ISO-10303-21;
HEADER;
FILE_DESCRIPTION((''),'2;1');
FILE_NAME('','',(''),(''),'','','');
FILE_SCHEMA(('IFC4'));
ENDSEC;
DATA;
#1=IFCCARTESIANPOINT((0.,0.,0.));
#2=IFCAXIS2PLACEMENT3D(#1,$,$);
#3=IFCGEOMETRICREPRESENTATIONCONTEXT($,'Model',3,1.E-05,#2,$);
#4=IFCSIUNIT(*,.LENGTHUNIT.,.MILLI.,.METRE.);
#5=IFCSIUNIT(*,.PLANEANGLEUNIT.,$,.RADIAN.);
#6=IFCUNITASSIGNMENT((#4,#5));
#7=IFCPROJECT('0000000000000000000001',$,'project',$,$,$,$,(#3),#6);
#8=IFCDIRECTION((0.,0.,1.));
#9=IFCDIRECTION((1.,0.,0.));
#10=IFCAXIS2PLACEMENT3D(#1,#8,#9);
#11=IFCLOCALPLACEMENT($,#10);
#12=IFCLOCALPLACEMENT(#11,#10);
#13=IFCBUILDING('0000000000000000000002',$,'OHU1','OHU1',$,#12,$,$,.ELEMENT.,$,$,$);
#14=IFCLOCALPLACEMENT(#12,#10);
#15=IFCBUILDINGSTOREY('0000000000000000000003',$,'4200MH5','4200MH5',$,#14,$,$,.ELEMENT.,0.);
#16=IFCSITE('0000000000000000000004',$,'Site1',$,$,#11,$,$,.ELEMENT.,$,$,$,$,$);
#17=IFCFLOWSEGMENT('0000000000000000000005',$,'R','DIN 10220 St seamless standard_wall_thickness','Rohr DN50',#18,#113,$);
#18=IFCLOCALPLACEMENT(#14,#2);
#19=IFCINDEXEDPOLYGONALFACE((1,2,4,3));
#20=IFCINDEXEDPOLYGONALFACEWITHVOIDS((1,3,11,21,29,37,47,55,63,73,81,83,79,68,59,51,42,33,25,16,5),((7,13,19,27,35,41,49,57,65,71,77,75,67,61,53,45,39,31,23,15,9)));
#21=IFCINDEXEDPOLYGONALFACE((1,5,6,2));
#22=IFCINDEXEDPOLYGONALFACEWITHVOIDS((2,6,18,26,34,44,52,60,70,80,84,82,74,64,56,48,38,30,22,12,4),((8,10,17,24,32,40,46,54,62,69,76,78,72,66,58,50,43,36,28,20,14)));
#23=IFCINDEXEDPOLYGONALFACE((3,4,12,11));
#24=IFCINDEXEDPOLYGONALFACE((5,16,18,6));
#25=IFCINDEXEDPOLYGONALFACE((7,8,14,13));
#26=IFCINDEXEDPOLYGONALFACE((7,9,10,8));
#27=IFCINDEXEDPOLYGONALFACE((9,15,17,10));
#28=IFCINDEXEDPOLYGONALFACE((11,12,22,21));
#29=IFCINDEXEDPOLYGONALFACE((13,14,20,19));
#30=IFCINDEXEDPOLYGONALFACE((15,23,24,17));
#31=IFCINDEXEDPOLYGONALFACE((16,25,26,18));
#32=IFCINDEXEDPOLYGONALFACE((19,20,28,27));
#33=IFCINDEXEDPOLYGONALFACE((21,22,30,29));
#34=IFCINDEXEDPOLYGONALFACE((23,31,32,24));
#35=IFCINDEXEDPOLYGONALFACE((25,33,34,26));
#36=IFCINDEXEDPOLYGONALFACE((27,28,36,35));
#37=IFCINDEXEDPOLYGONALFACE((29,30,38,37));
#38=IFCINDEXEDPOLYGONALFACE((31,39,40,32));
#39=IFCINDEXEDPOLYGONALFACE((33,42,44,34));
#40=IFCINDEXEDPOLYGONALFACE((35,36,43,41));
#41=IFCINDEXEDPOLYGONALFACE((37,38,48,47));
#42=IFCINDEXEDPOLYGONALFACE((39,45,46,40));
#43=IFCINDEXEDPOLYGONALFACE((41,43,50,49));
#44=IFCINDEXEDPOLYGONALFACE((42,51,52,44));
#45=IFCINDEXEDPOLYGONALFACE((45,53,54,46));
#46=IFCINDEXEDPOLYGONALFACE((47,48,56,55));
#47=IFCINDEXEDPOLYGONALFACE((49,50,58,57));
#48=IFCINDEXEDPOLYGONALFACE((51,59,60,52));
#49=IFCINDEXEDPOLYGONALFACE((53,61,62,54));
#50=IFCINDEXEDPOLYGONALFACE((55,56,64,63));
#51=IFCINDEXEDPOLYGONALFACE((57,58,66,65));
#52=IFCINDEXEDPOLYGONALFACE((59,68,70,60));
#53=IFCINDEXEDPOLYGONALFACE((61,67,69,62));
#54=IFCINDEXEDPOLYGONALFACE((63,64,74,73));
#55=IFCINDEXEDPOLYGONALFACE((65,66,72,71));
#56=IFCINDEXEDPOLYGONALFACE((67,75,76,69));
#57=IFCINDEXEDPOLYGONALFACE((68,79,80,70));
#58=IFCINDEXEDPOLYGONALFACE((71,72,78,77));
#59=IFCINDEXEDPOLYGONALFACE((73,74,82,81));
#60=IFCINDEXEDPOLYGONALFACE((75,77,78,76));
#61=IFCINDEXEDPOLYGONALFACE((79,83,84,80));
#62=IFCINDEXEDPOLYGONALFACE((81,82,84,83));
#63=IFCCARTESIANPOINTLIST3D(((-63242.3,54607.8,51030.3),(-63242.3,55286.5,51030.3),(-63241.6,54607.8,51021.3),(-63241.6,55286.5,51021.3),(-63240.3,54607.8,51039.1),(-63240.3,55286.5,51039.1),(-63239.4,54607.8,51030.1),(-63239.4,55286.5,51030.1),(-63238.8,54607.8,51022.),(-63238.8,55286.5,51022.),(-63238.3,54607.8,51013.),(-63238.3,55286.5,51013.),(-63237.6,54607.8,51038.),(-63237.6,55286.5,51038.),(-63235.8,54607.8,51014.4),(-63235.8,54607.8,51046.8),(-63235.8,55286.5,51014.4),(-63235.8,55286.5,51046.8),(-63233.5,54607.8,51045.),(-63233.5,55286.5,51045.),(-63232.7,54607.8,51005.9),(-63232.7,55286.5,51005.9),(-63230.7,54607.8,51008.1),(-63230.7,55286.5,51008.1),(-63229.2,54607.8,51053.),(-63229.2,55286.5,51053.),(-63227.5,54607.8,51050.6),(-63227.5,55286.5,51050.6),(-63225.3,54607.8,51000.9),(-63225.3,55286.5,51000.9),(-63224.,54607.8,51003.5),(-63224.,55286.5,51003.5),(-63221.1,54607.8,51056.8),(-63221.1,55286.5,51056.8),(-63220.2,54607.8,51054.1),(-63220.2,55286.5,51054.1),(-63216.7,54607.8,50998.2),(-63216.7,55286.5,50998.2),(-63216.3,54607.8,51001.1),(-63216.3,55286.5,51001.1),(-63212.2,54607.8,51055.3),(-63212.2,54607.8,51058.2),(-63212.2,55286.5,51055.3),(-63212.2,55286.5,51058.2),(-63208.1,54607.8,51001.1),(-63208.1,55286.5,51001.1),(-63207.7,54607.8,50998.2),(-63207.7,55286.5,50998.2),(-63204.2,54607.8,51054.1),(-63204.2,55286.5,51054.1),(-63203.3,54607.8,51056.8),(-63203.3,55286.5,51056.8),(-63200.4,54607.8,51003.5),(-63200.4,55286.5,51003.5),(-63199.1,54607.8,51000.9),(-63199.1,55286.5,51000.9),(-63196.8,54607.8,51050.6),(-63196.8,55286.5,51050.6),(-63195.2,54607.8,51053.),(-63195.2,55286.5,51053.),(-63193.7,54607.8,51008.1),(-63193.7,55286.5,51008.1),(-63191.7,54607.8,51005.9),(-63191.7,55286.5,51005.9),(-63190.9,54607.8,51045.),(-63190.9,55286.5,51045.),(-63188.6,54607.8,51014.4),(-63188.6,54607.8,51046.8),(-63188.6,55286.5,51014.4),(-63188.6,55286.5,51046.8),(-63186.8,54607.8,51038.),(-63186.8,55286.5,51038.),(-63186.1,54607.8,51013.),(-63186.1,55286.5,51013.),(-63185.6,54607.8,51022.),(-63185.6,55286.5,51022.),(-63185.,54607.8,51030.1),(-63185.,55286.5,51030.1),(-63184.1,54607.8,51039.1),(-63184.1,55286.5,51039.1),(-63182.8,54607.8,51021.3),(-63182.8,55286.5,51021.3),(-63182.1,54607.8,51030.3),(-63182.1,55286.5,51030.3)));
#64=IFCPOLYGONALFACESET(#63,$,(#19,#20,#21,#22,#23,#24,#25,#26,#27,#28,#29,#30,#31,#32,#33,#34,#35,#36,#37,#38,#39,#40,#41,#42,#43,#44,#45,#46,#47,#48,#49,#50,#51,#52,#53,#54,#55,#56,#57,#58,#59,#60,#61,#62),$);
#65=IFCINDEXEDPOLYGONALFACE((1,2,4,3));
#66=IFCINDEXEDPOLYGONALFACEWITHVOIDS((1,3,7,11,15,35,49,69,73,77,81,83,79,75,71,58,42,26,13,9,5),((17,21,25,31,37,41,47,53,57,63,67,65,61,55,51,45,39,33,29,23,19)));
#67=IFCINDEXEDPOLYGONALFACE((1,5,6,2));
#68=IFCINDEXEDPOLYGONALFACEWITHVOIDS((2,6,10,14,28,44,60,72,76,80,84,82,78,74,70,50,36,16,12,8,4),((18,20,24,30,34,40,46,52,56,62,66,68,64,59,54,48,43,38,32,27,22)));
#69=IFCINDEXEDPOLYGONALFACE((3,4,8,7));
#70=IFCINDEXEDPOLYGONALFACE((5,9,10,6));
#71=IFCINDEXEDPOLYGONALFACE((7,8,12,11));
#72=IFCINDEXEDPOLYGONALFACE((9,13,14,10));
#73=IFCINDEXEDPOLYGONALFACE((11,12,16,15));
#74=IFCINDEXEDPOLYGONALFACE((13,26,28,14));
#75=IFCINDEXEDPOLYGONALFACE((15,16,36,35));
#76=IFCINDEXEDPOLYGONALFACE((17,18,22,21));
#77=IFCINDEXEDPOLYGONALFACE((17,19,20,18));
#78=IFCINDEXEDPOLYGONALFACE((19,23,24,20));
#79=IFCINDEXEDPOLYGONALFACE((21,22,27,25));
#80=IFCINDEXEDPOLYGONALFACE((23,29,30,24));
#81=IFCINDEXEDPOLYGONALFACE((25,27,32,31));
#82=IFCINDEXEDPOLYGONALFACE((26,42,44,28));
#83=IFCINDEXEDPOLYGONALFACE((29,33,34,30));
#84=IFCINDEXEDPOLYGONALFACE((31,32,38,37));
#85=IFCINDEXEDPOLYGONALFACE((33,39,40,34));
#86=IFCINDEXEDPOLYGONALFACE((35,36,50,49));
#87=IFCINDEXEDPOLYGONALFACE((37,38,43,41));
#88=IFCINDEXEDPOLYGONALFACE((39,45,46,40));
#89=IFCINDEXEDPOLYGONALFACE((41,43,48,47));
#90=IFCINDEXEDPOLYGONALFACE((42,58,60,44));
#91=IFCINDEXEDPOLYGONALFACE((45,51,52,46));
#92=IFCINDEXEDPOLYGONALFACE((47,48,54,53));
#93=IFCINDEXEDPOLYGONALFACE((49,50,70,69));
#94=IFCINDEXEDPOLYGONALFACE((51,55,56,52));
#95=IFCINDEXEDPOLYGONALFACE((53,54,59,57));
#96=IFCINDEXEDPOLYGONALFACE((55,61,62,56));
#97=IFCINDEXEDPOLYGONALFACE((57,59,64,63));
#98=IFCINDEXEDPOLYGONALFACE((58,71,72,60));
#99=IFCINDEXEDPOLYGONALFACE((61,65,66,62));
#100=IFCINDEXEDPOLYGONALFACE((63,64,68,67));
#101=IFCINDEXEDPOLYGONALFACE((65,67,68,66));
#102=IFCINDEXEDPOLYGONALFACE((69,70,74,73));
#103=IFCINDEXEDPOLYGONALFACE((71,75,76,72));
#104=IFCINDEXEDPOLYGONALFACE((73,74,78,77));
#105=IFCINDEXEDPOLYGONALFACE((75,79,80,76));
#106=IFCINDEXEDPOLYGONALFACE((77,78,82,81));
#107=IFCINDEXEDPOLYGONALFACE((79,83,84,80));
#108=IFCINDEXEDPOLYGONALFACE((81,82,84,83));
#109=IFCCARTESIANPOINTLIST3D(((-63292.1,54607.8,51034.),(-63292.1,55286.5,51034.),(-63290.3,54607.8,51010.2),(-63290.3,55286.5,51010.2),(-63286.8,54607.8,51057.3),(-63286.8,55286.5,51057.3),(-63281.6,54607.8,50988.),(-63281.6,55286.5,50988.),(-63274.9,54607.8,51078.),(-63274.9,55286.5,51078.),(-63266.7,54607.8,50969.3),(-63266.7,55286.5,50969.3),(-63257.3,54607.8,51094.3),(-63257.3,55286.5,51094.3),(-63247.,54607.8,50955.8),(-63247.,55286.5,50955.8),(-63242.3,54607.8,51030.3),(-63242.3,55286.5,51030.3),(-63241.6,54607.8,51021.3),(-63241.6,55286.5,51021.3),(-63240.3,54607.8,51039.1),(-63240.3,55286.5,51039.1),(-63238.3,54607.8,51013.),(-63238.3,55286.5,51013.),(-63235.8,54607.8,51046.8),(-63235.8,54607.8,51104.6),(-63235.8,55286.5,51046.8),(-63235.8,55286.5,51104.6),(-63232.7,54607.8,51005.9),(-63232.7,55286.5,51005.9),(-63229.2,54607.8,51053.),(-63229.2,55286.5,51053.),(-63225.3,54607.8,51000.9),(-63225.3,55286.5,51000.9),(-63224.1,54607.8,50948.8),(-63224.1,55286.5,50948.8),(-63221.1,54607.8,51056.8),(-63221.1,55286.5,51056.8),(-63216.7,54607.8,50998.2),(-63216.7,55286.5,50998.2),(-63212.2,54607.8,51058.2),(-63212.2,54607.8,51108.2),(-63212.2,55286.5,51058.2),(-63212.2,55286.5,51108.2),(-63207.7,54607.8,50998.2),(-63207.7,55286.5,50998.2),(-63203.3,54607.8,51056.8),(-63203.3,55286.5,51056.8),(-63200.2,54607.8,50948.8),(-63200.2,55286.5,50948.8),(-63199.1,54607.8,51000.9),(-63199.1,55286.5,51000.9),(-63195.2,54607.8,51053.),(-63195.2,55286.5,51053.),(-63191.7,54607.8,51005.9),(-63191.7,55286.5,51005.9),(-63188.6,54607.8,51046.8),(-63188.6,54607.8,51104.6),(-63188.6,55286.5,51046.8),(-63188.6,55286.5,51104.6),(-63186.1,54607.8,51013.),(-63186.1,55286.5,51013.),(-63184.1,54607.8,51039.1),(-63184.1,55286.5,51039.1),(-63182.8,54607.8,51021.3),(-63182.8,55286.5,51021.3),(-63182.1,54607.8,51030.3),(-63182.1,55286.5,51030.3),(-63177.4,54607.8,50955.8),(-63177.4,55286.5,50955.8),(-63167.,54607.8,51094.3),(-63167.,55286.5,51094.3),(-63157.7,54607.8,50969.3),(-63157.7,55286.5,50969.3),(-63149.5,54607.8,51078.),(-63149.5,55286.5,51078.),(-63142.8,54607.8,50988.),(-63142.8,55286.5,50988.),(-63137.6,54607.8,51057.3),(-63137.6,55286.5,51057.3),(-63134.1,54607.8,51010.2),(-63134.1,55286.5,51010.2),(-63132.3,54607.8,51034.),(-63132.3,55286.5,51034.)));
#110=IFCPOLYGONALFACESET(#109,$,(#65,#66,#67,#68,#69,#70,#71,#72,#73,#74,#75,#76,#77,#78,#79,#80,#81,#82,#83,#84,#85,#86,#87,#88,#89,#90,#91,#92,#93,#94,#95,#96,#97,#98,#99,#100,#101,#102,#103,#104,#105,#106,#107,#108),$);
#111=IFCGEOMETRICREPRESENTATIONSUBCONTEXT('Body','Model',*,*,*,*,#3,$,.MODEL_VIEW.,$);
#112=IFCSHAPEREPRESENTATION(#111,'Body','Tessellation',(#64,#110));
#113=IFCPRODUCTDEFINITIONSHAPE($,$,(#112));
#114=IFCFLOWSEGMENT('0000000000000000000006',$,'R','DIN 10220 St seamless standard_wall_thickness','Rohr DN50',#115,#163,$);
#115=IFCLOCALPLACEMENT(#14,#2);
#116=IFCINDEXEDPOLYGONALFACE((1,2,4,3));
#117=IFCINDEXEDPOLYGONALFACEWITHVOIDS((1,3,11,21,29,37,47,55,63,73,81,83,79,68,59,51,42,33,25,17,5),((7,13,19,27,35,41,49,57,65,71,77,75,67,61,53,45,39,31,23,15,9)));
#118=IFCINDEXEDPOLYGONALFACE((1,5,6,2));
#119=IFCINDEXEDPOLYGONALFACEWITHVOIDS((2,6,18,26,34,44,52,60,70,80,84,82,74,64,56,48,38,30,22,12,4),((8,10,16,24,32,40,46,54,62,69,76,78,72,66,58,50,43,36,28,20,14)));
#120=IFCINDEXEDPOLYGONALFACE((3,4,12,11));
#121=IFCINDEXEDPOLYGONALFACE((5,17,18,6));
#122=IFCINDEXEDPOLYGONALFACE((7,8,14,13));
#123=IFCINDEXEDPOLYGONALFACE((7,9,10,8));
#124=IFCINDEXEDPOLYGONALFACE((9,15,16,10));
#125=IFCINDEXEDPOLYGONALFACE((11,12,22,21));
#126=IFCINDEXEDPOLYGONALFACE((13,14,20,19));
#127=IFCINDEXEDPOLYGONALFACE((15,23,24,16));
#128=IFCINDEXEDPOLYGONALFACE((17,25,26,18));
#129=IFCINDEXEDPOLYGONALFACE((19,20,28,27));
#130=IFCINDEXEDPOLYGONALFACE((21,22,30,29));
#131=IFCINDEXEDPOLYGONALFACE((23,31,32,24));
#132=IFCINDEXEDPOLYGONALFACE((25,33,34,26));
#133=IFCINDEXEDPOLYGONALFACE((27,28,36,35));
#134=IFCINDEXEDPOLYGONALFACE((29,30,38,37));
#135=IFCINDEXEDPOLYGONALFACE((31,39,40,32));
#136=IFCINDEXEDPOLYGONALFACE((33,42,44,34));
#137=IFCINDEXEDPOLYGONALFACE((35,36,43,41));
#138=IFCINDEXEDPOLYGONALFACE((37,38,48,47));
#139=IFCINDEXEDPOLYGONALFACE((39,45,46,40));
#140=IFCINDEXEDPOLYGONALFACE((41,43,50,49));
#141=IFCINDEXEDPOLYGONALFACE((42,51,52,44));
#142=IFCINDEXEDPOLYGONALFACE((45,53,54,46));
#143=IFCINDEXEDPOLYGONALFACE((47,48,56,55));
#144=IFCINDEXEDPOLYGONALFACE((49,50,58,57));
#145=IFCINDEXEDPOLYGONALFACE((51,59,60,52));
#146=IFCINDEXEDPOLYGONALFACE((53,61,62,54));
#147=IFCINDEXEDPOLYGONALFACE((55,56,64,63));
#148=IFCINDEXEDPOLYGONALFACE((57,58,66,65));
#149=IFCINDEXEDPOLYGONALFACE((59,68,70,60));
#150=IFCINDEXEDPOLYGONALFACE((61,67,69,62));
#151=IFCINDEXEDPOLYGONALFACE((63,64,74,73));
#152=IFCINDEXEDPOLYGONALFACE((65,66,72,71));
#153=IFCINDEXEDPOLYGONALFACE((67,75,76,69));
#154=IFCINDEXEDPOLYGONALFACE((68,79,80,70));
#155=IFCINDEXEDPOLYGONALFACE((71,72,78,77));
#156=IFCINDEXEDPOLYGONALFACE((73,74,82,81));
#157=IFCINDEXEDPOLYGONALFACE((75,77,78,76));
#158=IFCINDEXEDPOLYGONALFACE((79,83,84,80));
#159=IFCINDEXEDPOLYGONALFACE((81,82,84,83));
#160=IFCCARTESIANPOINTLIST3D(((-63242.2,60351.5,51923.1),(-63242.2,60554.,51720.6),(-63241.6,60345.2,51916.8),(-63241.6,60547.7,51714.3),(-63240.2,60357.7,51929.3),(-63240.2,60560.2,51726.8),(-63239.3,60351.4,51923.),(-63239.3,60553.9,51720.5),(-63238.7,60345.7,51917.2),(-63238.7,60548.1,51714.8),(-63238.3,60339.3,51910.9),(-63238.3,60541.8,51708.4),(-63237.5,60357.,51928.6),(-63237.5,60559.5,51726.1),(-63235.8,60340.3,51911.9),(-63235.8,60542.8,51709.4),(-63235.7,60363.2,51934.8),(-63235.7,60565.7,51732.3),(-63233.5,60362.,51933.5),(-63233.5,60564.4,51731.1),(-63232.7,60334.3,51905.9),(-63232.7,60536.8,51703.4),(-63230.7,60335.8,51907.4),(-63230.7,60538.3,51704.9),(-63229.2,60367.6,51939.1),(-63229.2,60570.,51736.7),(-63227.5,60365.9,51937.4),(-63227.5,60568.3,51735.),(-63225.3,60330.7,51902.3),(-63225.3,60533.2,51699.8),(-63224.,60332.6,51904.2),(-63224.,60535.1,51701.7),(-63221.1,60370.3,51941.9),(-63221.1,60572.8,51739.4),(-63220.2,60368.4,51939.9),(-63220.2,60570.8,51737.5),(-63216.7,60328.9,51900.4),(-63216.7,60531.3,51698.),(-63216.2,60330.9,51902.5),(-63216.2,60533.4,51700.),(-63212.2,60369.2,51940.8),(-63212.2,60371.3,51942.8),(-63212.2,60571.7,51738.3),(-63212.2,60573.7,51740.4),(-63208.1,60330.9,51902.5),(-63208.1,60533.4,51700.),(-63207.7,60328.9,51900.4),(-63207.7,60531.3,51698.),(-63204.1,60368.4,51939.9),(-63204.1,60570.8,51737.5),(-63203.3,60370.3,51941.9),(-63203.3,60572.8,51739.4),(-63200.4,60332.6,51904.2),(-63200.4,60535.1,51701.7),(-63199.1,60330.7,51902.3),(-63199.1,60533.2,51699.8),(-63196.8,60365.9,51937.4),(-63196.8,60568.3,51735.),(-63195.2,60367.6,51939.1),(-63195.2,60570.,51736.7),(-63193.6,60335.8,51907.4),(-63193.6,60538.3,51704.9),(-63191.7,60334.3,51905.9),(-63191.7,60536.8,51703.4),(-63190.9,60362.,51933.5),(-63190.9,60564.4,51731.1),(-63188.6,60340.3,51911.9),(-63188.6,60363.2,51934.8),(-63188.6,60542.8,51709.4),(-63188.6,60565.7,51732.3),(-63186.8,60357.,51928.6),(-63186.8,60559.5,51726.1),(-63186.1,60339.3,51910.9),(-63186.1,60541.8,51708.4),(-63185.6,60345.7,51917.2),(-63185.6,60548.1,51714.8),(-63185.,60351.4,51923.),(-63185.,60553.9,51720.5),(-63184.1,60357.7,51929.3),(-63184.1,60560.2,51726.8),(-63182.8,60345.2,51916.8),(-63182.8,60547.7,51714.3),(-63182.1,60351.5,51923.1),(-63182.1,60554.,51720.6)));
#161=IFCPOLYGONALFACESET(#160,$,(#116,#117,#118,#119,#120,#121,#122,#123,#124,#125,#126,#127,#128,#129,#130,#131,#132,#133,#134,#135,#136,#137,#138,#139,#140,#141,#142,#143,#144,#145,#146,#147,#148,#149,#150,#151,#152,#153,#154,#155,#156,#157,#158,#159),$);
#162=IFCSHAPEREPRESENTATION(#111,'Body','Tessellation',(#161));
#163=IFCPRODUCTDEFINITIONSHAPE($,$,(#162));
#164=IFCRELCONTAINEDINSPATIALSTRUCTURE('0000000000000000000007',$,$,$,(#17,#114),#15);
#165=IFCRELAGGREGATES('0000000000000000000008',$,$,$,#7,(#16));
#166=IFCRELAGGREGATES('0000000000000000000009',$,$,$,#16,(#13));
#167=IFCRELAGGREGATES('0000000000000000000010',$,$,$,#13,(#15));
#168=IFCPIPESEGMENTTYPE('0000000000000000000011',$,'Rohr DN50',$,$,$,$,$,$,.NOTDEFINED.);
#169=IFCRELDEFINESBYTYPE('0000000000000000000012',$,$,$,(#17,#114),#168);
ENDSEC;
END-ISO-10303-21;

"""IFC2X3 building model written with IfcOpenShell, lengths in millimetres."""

from ifc_helpers import new_model, si_unit, frame, origin, origin_with_axes, origin_2d_with_axis, place, context, subcontext, project, spatial, hollow_circle, extrude, type_object, element, save


model = new_model("IFC2X3")

# Units and contexts
model_context = context("Model", 3, precision=1e-05, world=origin())
body_context = subcontext(model_context, "Body", "Model", "MODEL_VIEW")
ifc_project = project(units=[si_unit("LENGTHUNIT", "METRE", prefix="MILLI"), si_unit("PLANEANGLEUNIT", "RADIAN")], contexts=[model_context])

# Site, building, storey
site_placement = place(None, origin_with_axes())
site = spatial("IfcSite", under=ifc_project, at=site_placement, Name="Site1", CompositionType="ELEMENT")
building_placement = place(site_placement, origin_with_axes())
building = spatial("IfcBuilding", under=site, at=building_placement, Name="OHU1", Description="OHU1", CompositionType="ELEMENT")
storey_placement = place(building_placement, origin_with_axes())
storey = spatial("IfcBuildingStorey", under=building, at=storey_placement, Name="4200MH5", Description="4200MH5", CompositionType="ELEMENT", Elevation=0.0)

# Flow segments
pipe_segment_type_1 = type_object("IfcPipeSegmentType", Name="Rohr DN50", PredefinedType="NOTDEFINED")
flow_segment_1_placement = place(storey_placement, frame((-63212.2, 54947.1, 51028.0), z_axis=(0.0, 0.0, 1.0), x_axis=(1.0, 0.0, 0.0)))
element("IfcFlowSegment", 1, at=flow_segment_1_placement, inside=storey, type_object=pipe_segment_type_1, Name="R", Description="DIN 10220 St seamless standard_wall_thickness", ObjectType="Rohr DN50", context=body_context, shape_type="SweptSolid", body=[
    extrude(hollow_circle(Radius=30.1, WallThickness=2.9, at=origin_2d_with_axis()), frame((0.0, -339.3, 0.0), z_axis=(0.000003, 1.0, 0.0), x_axis=(0.0, 0.0, 1.0)), (0.0, 0.0, 1.0), 678.7),
    extrude(hollow_circle(Radius=80.2, WallThickness=50.0, at=origin_2d_with_axis()), frame((0.0, -339.3, 0.0), z_axis=(0.000003, 1.0, 0.0), x_axis=(0.0, 0.0, 1.0)), (0.0, 0.0, 1.0), 678.7),
])
flow_segment_2_placement = place(storey_placement, frame((-63212.2, 60451.2, 51820.3), z_axis=(0.0, 0.0, 1.0), x_axis=(1.0, 0.0, 0.0)))
element("IfcFlowSegment", 2, at=flow_segment_2_placement, inside=storey, type_object=pipe_segment_type_1, Name="R", Description="DIN 10220 St seamless standard_wall_thickness", ObjectType="Rohr DN50", context=body_context, shape_type="SweptSolid", body=[
    extrude(hollow_circle(Radius=30.1, WallThickness=2.9, at=origin_2d_with_axis()), frame((0.0, -101.2, 101.2), z_axis=(0.000002, 0.707107, -0.707107), x_axis=(0.0, 0.0, 1.0)), (0.0, 0.0, 1.0), 286.3),
])

save(model, "model.ifc")
